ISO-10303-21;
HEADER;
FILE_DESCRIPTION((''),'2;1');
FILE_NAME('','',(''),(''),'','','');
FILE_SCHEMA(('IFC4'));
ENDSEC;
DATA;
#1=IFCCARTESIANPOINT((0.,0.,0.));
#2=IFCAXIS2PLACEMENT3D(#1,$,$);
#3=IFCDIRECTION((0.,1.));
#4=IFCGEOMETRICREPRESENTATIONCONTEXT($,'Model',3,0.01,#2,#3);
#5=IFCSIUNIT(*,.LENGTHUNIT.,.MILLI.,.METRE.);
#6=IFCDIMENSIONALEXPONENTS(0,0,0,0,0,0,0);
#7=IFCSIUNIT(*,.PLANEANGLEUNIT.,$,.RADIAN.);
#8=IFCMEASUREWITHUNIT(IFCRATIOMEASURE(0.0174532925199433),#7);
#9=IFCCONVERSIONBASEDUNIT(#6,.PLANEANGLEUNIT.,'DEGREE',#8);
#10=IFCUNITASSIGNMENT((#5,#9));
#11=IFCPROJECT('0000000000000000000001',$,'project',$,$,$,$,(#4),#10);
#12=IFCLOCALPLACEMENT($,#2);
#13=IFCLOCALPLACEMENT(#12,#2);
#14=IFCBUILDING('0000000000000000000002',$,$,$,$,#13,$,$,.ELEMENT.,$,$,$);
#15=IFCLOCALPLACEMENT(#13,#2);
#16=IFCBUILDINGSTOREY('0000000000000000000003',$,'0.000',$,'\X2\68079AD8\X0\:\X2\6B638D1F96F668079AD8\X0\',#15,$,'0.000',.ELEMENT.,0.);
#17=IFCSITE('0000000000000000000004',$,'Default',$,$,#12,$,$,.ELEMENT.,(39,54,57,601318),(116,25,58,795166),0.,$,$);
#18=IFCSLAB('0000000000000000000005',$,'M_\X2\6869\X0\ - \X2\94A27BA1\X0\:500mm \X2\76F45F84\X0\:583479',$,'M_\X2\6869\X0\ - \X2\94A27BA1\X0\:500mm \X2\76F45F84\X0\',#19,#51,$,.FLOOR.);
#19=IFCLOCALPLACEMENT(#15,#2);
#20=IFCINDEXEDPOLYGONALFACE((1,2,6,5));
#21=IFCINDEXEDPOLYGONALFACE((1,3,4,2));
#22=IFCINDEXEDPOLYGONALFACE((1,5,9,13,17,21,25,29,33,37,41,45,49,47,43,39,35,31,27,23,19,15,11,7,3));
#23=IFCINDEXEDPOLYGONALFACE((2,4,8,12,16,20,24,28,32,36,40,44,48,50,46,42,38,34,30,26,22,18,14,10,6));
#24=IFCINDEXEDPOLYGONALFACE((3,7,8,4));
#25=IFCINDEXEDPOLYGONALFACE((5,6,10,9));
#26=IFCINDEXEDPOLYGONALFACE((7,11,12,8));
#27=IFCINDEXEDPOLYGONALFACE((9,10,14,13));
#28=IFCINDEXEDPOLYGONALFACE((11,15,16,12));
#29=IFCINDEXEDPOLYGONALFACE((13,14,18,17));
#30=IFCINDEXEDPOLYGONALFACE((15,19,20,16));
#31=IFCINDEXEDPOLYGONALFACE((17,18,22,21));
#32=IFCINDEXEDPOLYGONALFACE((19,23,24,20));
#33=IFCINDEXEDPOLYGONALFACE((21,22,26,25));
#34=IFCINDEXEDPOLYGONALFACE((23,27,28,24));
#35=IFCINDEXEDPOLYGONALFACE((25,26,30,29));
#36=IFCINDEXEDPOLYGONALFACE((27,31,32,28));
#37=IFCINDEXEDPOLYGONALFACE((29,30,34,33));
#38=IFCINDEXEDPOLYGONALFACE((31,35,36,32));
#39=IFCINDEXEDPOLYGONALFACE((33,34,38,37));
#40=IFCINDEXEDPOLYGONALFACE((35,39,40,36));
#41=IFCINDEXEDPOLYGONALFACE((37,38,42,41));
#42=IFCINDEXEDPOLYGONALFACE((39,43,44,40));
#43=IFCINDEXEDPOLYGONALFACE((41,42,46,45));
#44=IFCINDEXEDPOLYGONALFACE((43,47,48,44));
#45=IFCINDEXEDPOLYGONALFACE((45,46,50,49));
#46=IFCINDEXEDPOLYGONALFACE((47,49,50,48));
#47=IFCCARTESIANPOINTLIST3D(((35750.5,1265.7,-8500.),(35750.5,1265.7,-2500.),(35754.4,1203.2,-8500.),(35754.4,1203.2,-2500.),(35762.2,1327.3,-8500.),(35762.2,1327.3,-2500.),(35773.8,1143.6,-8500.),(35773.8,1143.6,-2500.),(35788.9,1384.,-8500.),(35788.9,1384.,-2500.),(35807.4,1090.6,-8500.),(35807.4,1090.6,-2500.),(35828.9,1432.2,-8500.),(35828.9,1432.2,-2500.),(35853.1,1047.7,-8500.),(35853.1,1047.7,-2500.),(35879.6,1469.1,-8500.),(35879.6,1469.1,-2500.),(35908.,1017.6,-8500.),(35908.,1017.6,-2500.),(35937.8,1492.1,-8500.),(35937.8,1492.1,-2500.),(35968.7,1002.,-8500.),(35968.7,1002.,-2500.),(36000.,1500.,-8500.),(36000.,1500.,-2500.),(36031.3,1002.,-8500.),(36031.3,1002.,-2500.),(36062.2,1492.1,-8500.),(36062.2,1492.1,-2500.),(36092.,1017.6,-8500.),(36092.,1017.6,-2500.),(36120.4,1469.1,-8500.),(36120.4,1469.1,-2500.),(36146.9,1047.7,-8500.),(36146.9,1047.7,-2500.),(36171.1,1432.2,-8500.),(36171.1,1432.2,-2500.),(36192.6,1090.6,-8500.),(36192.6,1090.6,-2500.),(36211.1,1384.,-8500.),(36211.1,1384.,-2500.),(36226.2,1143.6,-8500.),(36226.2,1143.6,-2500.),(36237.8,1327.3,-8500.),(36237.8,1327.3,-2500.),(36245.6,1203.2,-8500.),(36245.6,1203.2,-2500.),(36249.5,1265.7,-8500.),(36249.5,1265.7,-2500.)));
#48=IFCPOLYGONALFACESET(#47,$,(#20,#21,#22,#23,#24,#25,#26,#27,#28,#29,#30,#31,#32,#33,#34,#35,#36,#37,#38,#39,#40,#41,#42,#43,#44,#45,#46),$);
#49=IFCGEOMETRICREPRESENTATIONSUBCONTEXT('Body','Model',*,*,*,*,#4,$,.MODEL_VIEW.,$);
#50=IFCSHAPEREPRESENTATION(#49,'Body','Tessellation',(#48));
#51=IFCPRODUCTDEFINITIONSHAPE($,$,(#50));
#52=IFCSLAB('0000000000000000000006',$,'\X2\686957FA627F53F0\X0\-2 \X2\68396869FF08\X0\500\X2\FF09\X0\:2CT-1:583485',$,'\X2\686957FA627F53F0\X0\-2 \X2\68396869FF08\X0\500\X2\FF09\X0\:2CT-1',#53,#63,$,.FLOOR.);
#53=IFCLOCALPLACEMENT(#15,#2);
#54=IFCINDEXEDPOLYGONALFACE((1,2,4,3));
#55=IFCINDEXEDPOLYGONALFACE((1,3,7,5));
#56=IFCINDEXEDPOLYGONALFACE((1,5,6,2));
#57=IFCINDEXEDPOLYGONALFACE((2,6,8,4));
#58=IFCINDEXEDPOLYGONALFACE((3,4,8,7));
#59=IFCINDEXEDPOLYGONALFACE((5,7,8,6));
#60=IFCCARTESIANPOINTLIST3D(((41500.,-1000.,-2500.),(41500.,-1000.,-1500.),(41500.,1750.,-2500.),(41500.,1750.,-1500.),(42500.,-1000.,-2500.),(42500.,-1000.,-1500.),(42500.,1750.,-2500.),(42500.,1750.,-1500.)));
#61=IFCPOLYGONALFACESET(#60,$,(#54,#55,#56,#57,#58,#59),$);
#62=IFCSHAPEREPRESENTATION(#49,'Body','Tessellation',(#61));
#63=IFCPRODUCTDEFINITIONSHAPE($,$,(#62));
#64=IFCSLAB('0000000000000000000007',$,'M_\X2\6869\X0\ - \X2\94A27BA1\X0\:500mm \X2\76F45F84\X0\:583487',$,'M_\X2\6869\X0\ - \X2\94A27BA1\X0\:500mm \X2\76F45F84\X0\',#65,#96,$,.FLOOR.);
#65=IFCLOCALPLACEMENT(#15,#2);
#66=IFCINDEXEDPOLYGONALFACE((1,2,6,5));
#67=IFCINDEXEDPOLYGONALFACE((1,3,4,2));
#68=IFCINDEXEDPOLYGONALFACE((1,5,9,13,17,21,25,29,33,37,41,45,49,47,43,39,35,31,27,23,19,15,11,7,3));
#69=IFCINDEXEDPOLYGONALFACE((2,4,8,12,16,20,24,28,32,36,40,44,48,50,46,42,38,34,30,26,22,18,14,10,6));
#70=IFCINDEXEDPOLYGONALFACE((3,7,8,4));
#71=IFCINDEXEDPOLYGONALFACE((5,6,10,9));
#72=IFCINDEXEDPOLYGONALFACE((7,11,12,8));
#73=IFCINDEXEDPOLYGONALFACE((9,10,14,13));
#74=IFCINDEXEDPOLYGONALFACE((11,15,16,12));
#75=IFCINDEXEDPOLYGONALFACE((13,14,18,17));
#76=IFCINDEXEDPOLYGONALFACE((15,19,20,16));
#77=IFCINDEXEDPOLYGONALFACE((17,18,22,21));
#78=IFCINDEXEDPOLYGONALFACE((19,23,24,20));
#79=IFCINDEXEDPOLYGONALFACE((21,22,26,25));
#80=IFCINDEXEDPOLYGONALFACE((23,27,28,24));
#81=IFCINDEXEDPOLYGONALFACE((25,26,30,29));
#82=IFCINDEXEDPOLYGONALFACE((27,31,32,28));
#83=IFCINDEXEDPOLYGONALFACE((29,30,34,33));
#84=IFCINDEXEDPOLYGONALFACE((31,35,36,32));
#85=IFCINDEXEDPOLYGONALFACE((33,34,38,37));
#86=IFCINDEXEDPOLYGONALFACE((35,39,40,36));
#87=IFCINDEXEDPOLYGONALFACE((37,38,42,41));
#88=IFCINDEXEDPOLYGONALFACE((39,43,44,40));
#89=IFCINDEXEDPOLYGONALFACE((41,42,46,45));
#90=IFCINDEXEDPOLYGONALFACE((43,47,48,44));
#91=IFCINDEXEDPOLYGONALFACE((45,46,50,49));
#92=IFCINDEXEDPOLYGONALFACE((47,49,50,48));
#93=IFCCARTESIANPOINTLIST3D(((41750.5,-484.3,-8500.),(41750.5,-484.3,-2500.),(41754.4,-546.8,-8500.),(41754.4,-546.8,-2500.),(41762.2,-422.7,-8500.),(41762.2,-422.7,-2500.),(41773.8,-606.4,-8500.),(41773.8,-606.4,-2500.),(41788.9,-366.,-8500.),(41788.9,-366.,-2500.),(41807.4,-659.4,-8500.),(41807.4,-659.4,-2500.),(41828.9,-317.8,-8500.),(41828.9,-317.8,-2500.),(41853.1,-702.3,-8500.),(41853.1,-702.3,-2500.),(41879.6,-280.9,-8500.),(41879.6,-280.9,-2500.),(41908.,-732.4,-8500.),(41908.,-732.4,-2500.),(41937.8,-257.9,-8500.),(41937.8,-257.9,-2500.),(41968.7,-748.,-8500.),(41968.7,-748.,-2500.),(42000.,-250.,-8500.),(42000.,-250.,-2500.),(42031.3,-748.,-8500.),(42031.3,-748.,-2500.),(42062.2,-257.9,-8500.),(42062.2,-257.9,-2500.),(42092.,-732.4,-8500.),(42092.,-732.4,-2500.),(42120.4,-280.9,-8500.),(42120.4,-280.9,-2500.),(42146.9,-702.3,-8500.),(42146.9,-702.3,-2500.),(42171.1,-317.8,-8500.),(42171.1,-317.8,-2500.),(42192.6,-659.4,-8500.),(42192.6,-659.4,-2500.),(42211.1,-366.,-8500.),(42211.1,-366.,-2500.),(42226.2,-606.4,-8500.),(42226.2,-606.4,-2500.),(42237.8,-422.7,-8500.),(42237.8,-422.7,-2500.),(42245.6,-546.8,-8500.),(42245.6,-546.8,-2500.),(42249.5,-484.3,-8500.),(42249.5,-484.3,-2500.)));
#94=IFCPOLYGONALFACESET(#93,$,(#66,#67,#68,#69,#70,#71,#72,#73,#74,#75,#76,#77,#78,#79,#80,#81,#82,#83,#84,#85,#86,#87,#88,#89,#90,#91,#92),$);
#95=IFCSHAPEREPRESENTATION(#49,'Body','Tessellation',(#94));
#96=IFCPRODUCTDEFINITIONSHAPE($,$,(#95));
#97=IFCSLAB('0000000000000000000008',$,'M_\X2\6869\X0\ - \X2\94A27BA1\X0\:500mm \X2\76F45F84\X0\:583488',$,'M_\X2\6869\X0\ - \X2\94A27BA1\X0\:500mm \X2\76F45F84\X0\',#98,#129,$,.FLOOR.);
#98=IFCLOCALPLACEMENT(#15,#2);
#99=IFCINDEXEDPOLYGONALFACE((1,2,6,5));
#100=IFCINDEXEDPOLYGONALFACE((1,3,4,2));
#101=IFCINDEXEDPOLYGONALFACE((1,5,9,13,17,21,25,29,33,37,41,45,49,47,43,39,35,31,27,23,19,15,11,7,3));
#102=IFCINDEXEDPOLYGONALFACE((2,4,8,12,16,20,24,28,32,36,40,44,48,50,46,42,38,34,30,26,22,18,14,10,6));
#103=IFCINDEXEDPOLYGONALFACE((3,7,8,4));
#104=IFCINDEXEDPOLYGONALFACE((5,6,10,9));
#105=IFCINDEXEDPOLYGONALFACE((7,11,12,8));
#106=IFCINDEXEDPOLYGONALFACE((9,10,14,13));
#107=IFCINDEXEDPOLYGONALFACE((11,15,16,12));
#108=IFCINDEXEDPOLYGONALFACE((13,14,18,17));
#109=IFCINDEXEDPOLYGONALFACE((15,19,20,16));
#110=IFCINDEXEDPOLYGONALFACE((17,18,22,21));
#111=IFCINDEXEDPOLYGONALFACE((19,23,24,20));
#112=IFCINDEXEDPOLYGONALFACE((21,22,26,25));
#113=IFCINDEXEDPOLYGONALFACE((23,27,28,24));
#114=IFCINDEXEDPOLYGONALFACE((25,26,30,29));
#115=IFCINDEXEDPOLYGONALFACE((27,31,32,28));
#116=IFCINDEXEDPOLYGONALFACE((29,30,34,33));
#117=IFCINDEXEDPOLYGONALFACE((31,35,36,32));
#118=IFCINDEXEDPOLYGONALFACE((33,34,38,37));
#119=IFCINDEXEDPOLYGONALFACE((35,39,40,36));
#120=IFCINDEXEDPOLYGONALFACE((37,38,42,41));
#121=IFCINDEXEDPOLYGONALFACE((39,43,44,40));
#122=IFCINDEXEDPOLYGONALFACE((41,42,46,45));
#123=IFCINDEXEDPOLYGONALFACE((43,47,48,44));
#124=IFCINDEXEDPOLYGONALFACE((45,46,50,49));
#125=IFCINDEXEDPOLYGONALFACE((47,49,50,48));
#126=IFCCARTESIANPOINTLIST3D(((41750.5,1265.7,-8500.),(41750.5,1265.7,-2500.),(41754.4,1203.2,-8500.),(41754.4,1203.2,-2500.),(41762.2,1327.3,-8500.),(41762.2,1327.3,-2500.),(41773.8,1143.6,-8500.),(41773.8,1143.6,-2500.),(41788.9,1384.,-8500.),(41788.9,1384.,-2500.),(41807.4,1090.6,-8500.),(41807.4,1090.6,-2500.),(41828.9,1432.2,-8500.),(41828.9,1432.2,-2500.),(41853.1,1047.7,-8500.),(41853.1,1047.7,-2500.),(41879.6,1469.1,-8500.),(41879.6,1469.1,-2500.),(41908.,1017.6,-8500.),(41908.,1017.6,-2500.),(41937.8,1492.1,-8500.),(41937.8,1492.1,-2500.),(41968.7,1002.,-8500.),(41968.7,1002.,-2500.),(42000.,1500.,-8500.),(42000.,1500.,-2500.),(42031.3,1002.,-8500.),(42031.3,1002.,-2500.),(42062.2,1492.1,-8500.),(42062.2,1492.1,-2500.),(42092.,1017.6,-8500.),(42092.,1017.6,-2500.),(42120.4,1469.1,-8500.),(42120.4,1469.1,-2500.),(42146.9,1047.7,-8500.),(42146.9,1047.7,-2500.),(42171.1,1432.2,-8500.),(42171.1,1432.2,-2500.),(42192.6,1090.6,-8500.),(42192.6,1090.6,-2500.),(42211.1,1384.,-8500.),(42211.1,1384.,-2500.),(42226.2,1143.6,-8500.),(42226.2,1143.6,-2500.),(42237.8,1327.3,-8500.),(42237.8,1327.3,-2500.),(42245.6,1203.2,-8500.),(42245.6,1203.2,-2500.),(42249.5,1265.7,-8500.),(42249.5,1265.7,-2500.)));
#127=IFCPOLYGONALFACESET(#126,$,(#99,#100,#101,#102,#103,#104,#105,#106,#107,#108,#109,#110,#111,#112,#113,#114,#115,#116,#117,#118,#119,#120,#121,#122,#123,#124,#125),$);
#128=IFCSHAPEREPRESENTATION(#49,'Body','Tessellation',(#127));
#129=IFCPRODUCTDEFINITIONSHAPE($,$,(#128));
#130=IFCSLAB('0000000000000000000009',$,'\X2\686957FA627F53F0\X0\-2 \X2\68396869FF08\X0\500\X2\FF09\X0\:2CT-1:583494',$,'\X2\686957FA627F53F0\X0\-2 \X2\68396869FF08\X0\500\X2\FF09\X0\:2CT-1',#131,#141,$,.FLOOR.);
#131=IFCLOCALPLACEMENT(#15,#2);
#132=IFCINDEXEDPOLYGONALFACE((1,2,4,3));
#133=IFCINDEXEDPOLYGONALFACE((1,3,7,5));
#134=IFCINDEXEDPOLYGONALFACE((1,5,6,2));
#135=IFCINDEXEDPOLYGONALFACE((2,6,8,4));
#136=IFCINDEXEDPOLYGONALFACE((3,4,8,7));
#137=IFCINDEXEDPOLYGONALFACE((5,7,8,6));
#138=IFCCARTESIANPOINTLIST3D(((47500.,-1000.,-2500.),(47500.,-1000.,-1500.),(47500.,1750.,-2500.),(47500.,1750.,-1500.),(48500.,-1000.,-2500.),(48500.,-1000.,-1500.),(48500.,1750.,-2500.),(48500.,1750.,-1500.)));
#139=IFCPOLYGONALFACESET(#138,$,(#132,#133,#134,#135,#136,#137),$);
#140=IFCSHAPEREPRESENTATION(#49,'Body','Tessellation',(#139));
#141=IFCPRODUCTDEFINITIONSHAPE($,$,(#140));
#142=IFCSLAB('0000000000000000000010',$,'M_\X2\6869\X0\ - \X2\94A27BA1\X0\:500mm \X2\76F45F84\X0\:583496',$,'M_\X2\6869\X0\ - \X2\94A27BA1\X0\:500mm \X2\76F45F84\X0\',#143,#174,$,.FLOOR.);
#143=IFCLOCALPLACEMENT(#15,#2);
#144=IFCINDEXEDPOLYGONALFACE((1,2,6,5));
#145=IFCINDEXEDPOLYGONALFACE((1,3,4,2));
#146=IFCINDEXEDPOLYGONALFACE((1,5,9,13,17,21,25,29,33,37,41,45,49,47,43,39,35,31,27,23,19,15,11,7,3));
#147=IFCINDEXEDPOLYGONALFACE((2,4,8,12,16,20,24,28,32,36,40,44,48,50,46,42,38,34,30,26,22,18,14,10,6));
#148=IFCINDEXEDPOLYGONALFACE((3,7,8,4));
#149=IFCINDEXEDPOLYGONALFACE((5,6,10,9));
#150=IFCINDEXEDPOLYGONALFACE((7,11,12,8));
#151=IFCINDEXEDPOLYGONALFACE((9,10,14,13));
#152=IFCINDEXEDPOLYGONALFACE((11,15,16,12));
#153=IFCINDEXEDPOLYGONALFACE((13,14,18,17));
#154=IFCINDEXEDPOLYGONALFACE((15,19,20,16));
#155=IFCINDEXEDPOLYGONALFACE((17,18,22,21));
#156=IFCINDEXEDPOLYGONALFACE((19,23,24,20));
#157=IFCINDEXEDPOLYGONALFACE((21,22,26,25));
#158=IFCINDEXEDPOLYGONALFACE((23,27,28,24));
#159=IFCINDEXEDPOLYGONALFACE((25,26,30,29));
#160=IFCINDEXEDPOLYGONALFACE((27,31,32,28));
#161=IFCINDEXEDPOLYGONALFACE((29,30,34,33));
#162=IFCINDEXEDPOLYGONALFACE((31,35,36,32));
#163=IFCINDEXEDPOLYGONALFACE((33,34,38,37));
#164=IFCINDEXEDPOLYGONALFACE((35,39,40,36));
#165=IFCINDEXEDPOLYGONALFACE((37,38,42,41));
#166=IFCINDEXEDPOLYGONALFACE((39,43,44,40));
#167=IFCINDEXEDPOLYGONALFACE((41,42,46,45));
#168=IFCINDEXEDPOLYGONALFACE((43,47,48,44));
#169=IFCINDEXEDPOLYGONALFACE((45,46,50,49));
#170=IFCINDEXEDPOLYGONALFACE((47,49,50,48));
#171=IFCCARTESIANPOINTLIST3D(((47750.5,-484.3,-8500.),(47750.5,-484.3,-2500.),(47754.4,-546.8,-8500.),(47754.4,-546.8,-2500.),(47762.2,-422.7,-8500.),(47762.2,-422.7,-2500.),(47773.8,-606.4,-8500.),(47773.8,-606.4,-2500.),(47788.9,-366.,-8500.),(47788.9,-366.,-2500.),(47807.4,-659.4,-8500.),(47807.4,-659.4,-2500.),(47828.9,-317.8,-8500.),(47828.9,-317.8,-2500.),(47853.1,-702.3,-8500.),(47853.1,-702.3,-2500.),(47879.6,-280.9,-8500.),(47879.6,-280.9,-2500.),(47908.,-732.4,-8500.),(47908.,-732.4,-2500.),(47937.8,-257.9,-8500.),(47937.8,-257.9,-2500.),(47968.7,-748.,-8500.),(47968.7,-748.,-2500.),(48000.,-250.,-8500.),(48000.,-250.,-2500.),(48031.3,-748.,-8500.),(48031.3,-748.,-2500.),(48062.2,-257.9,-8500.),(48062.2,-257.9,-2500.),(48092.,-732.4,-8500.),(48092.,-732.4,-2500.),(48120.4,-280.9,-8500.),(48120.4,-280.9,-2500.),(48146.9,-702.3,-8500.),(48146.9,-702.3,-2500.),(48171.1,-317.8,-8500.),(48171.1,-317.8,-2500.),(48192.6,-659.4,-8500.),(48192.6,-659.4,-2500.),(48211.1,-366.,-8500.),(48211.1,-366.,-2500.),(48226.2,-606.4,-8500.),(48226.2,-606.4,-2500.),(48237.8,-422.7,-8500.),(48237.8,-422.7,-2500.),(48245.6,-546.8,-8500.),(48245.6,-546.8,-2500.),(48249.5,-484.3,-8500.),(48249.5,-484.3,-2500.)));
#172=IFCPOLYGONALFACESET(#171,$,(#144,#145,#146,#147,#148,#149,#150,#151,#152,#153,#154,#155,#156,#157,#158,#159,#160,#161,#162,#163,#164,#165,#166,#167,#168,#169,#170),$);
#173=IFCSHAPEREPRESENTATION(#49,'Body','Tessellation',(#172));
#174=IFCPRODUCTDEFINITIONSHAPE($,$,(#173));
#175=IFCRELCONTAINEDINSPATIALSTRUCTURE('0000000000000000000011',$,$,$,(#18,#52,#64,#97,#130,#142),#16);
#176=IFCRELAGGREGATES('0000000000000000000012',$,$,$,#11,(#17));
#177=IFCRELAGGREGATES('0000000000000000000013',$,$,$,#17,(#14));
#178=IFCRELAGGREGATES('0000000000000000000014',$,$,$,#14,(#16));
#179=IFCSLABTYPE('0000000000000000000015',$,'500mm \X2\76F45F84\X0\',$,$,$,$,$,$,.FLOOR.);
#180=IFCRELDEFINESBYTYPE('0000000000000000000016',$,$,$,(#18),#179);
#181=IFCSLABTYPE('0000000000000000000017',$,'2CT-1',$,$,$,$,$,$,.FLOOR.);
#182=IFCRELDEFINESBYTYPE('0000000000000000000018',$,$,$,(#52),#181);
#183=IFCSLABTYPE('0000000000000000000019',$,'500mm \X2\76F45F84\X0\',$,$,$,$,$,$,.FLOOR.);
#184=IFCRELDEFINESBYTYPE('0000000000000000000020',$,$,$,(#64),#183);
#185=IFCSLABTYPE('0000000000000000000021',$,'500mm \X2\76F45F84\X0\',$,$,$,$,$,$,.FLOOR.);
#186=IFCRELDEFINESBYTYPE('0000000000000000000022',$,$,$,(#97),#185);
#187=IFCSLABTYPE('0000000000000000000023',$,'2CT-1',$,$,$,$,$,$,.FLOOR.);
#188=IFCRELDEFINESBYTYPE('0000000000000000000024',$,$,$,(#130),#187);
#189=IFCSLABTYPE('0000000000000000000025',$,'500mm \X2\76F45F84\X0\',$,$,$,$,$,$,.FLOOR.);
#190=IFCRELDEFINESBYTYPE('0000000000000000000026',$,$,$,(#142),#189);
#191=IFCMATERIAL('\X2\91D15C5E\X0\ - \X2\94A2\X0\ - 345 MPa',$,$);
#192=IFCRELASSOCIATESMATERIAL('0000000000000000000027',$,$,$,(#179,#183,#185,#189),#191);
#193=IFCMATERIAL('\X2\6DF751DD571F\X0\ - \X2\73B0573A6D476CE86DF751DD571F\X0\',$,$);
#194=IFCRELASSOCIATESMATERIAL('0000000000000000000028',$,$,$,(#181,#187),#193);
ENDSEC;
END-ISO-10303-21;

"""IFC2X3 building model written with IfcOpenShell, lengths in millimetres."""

from ifc_helpers import new_model, entity, si_unit, converted_unit, direction, frame, frame_2d, origin, origin_2d_with_axis, place, context, subcontext, project, spatial, rectangle, circle, extrude, material, type_object, element, save


model = new_model("IFC2X3")

# Units and contexts
model_context = context("Model", 3, precision=0.01, world=origin(), true_north=direction((0.0, 1.0)))
body_context = subcontext(model_context, "Body", "Model", "MODEL_VIEW")
ifc_project = project(units=[si_unit("LENGTHUNIT", "METRE", prefix="MILLI"), converted_unit("PLANEANGLEUNIT", "DEGREE", entity("IfcRatioMeasure", 0.0174532925199433), si_unit("PLANEANGLEUNIT", "RADIAN"), dimensions=[0, 0, 0, 0, 0, 0, 0])], contexts=[model_context])

# Site, building, storey
site_placement = place(None, origin())
site = spatial("IfcSite", under=ifc_project, at=site_placement, Name="Default", CompositionType="ELEMENT", RefLatitude=(39, 54, 57, 601318), RefLongitude=(116, 25, 58, 795166), RefElevation=0.0)
building_placement = place(site_placement, origin())
building = spatial("IfcBuilding", under=site, at=building_placement, CompositionType="ELEMENT")
storey_placement = place(building_placement, origin())
storey = spatial("IfcBuildingStorey", under=building, at=storey_placement, Name="0.000", ObjectType="标高:正负零标高", LongName="0.000", CompositionType="ELEMENT", Elevation=0.0)

# Slabs
ifc_material_1 = material(Name="金属 - 钢 - 345 MPa")
slab_type_1 = type_object("IfcSlabType", Name="500mm 直径", PredefinedType="FLOOR", material=ifc_material_1)
slab_1_placement = place(storey_placement, origin())
element("IfcSlab", 1, at=slab_1_placement, inside=storey, type_object=slab_type_1, Name="M_桩 - 钢管:500mm 直径:583479", ObjectType="M_桩 - 钢管:500mm 直径", PredefinedType="FLOOR", context=body_context, shape_type="SweptSolid", body=[
    extrude(circle(Radius=250.0, at=origin_2d_with_axis()), frame((36000.0, 1250.0, -8500.0), z_axis=(0.0, 0.0, 1.0), x_axis=(0.0, 1.0, 0.0)), (0.0, 0.0, 1.0), 6000.0),
])
ifc_material_2 = material(Name="混凝土 - 现场浇注混凝土")
slab_type_2 = type_object("IfcSlabType", Name="2CT-1", PredefinedType="FLOOR", material=ifc_material_2)
slab_2_placement = place(storey_placement, origin())
element("IfcSlab", 2, at=slab_2_placement, inside=storey, type_object=slab_type_2, Name="桩基承台-2 根桩（500）:2CT-1:583485", ObjectType="桩基承台-2 根桩（500）:2CT-1", PredefinedType="FLOOR", context=body_context, shape_type="SweptSolid", body=[
    extrude(rectangle(XDim=2750.0, YDim=1000.0, at=frame_2d((0.0, 0.0), x_axis=(1.0, 0.0))), frame((42000.0, 375.0, -2500.0), z_axis=(0.0, 0.0, 1.0), x_axis=(0.0, -1.0, 0.0)), (0.0, 0.0, 1.0), 1000.0),
])
slab_type_3 = type_object("IfcSlabType", Name="500mm 直径", PredefinedType="FLOOR", material=ifc_material_1)
slab_3_placement = place(storey_placement, origin())
element("IfcSlab", 3, at=slab_3_placement, inside=storey, type_object=slab_type_3, Name="M_桩 - 钢管:500mm 直径:583487", ObjectType="M_桩 - 钢管:500mm 直径", PredefinedType="FLOOR", context=body_context, shape_type="SweptSolid", body=[
    extrude(circle(Radius=250.0, at=frame_2d((0.0, 0.0), x_axis=(1.0, 0.0))), frame((42000.0, -500.0, -8500.0), z_axis=(0.0, 0.0, 1.0), x_axis=(0.0, 1.0, 0.0)), (0.0, 0.0, 1.0), 6000.0),
])
slab_type_4 = type_object("IfcSlabType", Name="500mm 直径", PredefinedType="FLOOR", material=ifc_material_1)
slab_4_placement = place(storey_placement, origin())
element("IfcSlab", 4, at=slab_4_placement, inside=storey, type_object=slab_type_4, Name="M_桩 - 钢管:500mm 直径:583488", ObjectType="M_桩 - 钢管:500mm 直径", PredefinedType="FLOOR", context=body_context, shape_type="SweptSolid", body=[
    extrude(circle(Radius=250.0, at=origin_2d_with_axis()), frame((42000.0, 1250.0, -8500.0), z_axis=(0.0, 0.0, 1.0), x_axis=(0.0, 1.0, 0.0)), (0.0, 0.0, 1.0), 6000.0),
])
slab_type_5 = type_object("IfcSlabType", Name="2CT-1", PredefinedType="FLOOR", material=ifc_material_2)
slab_5_placement = place(storey_placement, origin())
element("IfcSlab", 5, at=slab_5_placement, inside=storey, type_object=slab_type_5, Name="桩基承台-2 根桩（500）:2CT-1:583494", ObjectType="桩基承台-2 根桩（500）:2CT-1", PredefinedType="FLOOR", context=body_context, shape_type="SweptSolid", body=[
    extrude(rectangle(XDim=2750.0, YDim=1000.0, at=frame_2d((0.0, 0.0), x_axis=(1.0, 0.0))), frame((48000.0, 375.0, -2500.0), z_axis=(0.0, 0.0, 1.0), x_axis=(0.0, -1.0, 0.0)), (0.0, 0.0, 1.0), 1000.0),
])
slab_type_6 = type_object("IfcSlabType", Name="500mm 直径", PredefinedType="FLOOR", material=ifc_material_1)
slab_6_placement = place(storey_placement, origin())
element("IfcSlab", 6, at=slab_6_placement, inside=storey, type_object=slab_type_6, Name="M_桩 - 钢管:500mm 直径:583496", ObjectType="M_桩 - 钢管:500mm 直径", PredefinedType="FLOOR", context=body_context, shape_type="SweptSolid", body=[
    extrude(circle(Radius=250.0, at=frame_2d((0.0, 0.0), x_axis=(1.0, 0.0))), frame((48000.0, -500.0, -8500.0), z_axis=(0.0, 0.0, 1.0), x_axis=(0.0, 1.0, 0.0)), (0.0, 0.0, 1.0), 6000.0),
])

save(model, "model.ifc")
